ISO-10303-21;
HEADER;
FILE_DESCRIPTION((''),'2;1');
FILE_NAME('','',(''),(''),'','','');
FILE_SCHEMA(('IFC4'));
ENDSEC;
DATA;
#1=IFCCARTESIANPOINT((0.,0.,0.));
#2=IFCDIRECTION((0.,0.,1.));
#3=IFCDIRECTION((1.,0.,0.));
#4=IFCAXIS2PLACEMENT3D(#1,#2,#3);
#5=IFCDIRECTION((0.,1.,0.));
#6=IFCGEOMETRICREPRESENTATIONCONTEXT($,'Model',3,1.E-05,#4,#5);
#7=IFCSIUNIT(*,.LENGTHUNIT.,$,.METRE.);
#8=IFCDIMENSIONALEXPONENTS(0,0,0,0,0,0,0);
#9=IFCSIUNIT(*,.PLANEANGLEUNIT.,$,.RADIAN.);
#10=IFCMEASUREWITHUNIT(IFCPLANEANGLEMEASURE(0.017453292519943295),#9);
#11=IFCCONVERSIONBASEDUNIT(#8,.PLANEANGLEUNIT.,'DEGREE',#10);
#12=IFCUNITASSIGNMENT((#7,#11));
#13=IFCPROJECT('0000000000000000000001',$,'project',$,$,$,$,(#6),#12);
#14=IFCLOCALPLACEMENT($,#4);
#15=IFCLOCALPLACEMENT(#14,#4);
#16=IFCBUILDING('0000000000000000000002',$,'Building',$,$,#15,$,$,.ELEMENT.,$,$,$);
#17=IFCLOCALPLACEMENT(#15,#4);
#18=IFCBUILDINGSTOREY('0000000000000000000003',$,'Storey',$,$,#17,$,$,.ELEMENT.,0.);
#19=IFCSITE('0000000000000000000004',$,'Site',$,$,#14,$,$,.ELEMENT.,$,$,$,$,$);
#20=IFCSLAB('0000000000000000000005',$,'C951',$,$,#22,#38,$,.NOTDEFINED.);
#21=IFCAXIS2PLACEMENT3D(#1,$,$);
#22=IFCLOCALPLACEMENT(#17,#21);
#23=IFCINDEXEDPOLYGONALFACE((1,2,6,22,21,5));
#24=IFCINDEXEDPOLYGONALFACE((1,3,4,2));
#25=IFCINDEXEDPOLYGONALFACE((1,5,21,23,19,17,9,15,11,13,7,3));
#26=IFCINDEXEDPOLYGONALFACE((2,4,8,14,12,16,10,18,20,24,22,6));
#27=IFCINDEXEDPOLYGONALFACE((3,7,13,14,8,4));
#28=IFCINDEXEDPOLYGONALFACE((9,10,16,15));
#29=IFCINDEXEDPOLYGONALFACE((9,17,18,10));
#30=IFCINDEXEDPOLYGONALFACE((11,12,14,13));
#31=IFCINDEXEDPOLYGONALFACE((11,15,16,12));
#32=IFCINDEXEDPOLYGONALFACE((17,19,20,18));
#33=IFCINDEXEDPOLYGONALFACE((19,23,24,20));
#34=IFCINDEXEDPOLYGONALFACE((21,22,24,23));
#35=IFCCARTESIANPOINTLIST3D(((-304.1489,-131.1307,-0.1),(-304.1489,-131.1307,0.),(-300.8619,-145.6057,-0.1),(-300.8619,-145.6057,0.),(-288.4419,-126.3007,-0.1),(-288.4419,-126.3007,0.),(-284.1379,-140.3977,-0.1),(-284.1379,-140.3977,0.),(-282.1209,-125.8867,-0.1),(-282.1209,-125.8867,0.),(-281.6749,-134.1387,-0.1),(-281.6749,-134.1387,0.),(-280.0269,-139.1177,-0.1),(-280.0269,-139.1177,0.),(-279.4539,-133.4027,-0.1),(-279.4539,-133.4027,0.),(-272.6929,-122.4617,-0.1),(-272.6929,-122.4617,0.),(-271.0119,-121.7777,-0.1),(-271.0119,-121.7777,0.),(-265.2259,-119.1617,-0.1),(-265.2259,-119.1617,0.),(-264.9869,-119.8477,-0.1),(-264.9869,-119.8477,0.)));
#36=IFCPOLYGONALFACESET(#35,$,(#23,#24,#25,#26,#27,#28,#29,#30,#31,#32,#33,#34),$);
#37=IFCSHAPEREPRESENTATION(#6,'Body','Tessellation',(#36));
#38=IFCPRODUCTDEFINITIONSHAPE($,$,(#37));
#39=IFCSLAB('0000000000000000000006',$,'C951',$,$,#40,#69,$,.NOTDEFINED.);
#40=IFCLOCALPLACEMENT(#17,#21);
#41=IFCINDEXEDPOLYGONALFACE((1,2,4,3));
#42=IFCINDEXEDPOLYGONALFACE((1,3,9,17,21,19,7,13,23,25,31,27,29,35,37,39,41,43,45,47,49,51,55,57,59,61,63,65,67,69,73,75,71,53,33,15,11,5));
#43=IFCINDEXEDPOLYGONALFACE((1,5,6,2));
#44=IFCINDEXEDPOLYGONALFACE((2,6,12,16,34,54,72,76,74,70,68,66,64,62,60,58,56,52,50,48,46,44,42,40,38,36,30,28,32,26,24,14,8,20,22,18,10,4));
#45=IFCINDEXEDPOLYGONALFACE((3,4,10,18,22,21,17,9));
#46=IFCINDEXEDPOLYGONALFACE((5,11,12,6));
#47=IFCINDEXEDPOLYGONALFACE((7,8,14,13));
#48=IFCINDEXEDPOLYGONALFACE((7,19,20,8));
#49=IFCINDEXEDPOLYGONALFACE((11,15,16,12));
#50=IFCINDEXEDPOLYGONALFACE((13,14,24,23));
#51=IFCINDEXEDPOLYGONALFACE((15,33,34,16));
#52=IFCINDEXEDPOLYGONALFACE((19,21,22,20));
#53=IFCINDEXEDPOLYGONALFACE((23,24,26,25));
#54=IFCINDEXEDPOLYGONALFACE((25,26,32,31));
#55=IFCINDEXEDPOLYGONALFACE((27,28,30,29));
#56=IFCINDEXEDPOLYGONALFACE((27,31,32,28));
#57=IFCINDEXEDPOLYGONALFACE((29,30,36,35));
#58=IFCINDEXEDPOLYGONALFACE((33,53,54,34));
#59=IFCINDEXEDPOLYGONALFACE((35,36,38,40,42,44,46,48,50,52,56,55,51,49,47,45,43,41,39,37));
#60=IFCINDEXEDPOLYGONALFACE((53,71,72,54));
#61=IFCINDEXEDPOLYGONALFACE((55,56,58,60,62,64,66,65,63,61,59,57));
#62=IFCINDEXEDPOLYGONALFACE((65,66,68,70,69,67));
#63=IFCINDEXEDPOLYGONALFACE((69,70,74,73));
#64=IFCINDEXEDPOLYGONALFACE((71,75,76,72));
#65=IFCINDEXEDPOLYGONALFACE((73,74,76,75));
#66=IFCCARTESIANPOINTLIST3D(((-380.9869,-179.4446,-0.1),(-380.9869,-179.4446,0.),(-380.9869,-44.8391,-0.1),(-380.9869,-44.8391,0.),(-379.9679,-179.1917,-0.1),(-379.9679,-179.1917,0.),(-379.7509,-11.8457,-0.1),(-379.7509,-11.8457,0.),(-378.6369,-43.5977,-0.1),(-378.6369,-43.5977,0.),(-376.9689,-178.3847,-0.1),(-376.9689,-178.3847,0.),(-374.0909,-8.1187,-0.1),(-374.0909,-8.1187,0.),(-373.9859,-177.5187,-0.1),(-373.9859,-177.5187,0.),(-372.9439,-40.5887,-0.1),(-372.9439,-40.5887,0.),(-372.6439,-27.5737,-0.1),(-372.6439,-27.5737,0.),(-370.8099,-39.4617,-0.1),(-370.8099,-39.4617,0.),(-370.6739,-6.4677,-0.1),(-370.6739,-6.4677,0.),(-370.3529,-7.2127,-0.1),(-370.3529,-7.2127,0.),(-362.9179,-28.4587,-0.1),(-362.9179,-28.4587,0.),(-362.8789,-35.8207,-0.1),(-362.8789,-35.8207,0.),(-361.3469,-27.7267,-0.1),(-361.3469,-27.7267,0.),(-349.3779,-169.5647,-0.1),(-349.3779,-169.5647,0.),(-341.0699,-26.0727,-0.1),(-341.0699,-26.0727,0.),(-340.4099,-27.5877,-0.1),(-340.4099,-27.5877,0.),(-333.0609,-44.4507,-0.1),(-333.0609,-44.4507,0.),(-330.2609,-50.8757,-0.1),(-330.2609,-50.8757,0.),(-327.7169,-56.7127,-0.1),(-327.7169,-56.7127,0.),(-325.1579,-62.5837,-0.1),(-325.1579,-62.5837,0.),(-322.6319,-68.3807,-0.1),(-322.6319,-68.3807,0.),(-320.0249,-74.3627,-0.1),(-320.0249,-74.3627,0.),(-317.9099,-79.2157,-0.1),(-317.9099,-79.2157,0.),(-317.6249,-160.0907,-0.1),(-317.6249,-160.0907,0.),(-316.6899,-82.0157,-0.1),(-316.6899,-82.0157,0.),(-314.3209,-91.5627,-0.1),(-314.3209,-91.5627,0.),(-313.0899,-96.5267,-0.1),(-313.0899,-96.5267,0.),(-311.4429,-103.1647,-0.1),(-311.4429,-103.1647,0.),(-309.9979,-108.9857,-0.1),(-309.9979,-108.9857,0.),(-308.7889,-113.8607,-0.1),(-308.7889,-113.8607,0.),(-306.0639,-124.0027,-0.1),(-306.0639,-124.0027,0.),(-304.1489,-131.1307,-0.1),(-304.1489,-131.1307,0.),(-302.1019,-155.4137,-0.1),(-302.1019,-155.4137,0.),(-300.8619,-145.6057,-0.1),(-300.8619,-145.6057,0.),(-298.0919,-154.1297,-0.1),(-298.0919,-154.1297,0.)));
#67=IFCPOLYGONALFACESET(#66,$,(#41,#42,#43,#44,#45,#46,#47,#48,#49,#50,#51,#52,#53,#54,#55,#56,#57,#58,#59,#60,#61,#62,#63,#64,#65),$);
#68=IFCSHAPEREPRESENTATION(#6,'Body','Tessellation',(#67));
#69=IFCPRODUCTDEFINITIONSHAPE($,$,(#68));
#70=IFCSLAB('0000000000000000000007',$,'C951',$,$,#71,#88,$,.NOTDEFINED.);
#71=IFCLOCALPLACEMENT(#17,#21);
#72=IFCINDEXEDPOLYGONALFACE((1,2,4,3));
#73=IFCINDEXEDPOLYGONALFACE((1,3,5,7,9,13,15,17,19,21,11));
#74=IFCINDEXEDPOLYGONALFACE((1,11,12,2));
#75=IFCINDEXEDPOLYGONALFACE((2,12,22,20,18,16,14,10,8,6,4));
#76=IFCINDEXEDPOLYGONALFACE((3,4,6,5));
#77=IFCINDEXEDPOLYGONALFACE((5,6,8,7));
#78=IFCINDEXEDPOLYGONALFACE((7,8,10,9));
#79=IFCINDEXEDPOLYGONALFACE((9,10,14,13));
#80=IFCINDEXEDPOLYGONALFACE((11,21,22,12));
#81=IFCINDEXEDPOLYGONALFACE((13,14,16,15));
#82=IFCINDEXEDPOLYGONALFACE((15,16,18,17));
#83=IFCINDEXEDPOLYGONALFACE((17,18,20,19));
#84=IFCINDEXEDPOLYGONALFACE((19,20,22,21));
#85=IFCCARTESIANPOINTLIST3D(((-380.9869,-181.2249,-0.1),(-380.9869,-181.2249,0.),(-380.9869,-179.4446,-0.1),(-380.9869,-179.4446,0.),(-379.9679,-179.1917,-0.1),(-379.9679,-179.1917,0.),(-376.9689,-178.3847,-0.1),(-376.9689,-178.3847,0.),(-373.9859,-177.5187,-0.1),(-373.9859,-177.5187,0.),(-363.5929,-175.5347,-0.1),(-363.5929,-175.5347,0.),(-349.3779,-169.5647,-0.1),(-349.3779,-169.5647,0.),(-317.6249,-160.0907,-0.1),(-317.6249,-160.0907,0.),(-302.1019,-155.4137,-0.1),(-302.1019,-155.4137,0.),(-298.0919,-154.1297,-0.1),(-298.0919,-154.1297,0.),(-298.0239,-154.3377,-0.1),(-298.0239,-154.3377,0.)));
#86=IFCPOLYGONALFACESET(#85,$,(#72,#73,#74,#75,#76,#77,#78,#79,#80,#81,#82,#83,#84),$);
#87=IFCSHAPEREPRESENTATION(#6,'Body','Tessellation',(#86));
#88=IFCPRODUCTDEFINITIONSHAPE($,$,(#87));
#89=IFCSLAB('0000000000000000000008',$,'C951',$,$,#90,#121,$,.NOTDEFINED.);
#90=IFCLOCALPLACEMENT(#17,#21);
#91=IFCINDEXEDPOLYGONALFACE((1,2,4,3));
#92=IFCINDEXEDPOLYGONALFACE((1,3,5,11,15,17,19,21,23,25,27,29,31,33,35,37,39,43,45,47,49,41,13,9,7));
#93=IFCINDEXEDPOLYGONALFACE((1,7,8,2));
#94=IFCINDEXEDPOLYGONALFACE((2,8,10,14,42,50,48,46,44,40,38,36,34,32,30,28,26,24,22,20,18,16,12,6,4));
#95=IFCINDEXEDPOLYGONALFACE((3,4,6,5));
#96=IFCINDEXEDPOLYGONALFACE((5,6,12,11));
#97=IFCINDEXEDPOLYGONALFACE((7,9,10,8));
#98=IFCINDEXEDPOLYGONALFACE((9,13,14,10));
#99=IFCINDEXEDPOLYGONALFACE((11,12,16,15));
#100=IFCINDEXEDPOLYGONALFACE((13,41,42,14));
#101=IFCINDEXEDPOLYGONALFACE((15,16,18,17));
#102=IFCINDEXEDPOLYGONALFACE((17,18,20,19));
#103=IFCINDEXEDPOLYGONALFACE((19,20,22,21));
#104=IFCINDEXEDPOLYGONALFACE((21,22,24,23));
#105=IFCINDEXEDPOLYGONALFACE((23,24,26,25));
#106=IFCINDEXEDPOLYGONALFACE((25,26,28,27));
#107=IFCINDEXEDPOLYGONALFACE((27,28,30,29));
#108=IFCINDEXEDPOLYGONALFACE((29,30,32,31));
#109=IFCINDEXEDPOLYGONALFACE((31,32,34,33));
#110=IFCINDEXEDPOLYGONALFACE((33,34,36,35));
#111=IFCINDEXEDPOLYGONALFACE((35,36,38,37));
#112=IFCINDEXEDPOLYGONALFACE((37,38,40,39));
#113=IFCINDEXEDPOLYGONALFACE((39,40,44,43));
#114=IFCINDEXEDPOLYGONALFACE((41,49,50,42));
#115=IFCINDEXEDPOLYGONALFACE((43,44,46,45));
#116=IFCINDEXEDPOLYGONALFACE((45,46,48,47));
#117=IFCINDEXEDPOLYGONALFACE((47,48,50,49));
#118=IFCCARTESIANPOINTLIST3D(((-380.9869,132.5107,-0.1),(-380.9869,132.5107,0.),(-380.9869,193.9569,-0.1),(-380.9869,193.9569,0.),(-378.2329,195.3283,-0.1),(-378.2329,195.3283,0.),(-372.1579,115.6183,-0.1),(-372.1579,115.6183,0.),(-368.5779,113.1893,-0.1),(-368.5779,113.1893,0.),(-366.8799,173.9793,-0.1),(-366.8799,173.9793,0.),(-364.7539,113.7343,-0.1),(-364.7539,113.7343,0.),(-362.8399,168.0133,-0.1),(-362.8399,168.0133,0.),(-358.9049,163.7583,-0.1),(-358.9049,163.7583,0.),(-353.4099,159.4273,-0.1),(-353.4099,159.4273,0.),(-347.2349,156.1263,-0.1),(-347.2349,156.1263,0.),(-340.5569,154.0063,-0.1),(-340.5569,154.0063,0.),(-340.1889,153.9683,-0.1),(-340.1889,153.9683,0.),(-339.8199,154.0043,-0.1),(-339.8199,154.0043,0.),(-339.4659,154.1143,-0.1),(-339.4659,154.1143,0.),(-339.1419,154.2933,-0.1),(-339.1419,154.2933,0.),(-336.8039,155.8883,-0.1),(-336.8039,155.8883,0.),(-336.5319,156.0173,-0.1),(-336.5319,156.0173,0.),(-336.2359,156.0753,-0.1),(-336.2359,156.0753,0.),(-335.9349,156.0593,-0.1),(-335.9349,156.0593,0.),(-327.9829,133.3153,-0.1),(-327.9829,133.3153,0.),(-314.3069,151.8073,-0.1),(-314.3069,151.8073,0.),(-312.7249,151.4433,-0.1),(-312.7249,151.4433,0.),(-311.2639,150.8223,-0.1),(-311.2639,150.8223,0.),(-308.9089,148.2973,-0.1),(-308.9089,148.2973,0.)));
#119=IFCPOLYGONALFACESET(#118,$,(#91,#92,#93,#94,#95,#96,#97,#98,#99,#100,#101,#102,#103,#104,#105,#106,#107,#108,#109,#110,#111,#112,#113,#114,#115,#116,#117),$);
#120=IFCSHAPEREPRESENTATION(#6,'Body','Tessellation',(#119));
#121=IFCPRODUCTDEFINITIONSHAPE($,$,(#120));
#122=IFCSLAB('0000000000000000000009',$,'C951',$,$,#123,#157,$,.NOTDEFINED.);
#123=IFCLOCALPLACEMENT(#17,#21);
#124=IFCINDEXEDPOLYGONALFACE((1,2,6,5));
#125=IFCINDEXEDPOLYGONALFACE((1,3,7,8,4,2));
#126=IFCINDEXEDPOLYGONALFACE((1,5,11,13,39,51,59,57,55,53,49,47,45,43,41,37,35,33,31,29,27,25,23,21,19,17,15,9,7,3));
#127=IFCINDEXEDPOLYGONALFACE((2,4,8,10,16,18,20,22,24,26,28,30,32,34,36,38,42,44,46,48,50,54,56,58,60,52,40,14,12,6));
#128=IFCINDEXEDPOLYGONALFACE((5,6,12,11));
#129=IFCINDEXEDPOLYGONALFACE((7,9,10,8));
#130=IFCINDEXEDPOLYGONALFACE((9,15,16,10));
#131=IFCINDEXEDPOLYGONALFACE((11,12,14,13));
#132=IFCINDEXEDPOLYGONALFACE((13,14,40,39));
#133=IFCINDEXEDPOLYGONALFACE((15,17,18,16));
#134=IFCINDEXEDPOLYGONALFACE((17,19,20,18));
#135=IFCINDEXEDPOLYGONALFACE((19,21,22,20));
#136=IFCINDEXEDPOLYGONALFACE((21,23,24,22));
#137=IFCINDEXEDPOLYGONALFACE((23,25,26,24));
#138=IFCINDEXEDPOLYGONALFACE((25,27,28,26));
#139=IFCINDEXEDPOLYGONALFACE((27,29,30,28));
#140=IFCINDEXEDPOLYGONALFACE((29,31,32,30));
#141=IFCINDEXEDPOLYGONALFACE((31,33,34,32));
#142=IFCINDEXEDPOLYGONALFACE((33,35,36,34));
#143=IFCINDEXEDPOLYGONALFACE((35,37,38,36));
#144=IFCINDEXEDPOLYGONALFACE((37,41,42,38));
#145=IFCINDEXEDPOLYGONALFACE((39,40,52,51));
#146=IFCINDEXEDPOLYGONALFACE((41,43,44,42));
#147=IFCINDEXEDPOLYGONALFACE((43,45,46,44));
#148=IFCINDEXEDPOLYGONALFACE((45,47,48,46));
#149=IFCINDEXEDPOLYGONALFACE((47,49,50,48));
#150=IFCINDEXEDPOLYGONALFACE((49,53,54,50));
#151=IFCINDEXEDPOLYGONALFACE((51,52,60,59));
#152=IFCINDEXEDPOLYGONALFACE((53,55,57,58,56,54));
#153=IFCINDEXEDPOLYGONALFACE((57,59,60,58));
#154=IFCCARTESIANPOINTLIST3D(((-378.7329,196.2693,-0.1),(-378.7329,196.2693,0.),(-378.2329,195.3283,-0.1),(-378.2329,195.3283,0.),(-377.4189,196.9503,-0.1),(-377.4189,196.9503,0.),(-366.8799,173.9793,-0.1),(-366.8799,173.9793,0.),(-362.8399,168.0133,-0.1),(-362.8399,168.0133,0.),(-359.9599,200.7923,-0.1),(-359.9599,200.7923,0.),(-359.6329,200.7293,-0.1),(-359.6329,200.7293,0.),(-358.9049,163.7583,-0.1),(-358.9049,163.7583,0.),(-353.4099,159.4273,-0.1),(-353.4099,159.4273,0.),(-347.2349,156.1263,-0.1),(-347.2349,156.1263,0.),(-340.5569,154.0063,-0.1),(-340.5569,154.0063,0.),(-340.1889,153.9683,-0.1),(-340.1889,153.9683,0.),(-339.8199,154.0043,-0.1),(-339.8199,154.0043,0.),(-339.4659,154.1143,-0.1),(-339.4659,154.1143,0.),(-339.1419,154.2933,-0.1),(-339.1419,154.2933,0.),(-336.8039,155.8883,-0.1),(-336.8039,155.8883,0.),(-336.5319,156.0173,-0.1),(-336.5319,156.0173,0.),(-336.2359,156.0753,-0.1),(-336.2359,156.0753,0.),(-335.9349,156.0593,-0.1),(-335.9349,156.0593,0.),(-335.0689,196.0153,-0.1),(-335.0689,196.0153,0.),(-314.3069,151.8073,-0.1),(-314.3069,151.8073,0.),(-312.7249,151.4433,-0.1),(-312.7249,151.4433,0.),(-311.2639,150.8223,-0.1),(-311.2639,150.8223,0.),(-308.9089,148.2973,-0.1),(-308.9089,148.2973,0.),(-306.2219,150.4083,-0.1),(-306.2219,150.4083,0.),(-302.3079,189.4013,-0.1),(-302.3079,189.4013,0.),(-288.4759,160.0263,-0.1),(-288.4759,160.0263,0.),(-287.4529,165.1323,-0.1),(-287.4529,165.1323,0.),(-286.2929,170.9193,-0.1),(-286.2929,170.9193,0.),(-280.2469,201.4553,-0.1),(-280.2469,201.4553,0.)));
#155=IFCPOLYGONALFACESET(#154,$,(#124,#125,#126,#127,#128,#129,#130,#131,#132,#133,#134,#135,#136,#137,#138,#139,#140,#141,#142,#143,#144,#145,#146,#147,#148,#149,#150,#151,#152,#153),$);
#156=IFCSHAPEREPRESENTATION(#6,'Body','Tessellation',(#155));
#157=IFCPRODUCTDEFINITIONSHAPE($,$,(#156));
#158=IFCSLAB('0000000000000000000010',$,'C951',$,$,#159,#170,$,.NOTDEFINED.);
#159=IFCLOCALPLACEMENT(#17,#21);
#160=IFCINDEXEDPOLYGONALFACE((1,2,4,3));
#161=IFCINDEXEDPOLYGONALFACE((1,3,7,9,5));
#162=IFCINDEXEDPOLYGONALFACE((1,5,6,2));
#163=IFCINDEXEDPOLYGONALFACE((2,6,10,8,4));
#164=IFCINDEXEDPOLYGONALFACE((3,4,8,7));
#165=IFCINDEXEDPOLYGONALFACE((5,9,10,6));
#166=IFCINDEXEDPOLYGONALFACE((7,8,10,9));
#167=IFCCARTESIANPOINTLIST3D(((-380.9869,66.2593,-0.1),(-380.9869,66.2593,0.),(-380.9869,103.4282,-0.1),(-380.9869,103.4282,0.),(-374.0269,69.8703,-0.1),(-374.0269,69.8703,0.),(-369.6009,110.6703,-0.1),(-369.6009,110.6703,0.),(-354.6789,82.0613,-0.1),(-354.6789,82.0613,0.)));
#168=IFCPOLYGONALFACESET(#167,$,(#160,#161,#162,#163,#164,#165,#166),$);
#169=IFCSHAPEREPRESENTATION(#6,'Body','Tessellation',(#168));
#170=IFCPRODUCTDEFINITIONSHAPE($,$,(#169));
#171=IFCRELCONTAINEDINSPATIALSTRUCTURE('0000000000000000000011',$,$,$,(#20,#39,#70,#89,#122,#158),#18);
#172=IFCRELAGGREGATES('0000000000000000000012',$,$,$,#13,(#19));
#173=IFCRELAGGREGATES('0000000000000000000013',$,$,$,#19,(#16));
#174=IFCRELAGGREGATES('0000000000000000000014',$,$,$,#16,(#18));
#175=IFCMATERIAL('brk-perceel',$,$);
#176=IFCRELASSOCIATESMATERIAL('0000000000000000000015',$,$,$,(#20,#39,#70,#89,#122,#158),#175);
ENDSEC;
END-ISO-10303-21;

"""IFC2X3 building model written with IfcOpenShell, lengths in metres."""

from ifc_helpers import new_model, entity, si_unit, converted_unit, direction, frame, origin_with_axes, place, context, project, spatial, polyline, outline, extrude, material, element, save


model = new_model("IFC2X3")

# Units and contexts
model_context = context("Model", 3, precision=1e-05, world=origin_with_axes(), true_north=direction((0.0, 1.0, 0.0)))
ifc_project = project(units=[si_unit("LENGTHUNIT", "METRE"), converted_unit("PLANEANGLEUNIT", "DEGREE", entity("IfcPlaneAngleMeasure", 0.017453292519943295), si_unit("PLANEANGLEUNIT", "RADIAN"), dimensions=[0, 0, 0, 0, 0, 0, 0])], contexts=[model_context])

# Site, building, storey
site_placement = place(None, origin_with_axes())
site = spatial("IfcSite", under=ifc_project, at=site_placement, Name="Site", CompositionType="ELEMENT")
building_placement = place(site_placement, origin_with_axes())
building = spatial("IfcBuilding", under=site, at=building_placement, Name="Building", CompositionType="ELEMENT")
storey_placement = place(building_placement, origin_with_axes())
storey = spatial("IfcBuildingStorey", under=building, at=storey_placement, Name="Storey", CompositionType="ELEMENT", Elevation=0.0)

# Slabs
ifc_material = material(Name="brk-perceel")
slab_1_placement = place(storey_placement, frame((0.0, 0.0, -0.1), z_axis=(0.0, 0.0, 1.0), x_axis=(1.0, 0.0, 0.0)))
element("IfcSlab", 1, at=slab_1_placement, inside=storey, material=ifc_material, Name="C951", PredefinedType="NOTDEFINED", context=model_context, shape_type="SweptSolid", body=[
    extrude(outline(polyline([(-304.1489, -131.1307), (-288.4419, -126.3007), (-265.2259, -119.1617), (-264.9869, -119.8477), (-271.0119, -121.7777), (-272.6929, -122.4617), (-282.1209, -125.8867), (-279.4539, -133.4027), (-281.6749, -134.1387), (-280.0269, -139.1177), (-284.1379, -140.3977), (-300.8619, -145.6057), (-304.1489, -131.1307)])), origin_with_axes(), (0.0, 0.0, 1.0), 0.1),
])
slab_2_placement = place(storey_placement, frame((0.0, 0.0, -0.1), z_axis=(0.0, 0.0, 1.0), x_axis=(1.0, 0.0, 0.0)))
element("IfcSlab", 2, at=slab_2_placement, inside=storey, material=ifc_material, Name="C951", PredefinedType="NOTDEFINED", context=model_context, shape_type="SweptSolid", body=[
    extrude(outline(polyline([(-378.6369, -43.5977), (-372.9439, -40.5887), (-370.8099, -39.4617), (-372.6439, -27.5737), (-379.7509, -11.8457), (-374.0909, -8.1187), (-370.6739, -6.4677), (-370.3529, -7.2127), (-361.3469, -27.7267), (-362.9179, -28.4587), (-362.8789, -35.8207), (-341.0699, -26.0727), (-340.4099, -27.5877), (-333.0609, -44.4507), (-330.2609, -50.8757), (-327.7169, -56.7127), (-325.1579, -62.5837), (-322.6319, -68.3807), (-320.0249, -74.3627), (-317.9099, -79.2157), (-316.6899, -82.0157), (-314.3209, -91.5627), (-313.0899, -96.5267), (-311.4429, -103.1647), (-309.9979, -108.9857), (-308.7889, -113.8607), (-306.0639, -124.0027), (-304.1489, -131.1307), (-300.8619, -145.6057), (-298.0919, -154.1297), (-302.1019, -155.4137), (-317.6249, -160.0907), (-349.3779, -169.5647), (-373.9859, -177.5187), (-376.9689, -178.3847), (-379.9679, -179.1917), (-380.9869, -179.4446), (-380.9869, -44.8391), (-378.6369, -43.5977)])), origin_with_axes(), (0.0, 0.0, 1.0), 0.1),
])
slab_3_placement = place(storey_placement, frame((0.0, 0.0, -0.1), z_axis=(0.0, 0.0, 1.0), x_axis=(1.0, 0.0, 0.0)))
element("IfcSlab", 3, at=slab_3_placement, inside=storey, material=ifc_material, Name="C951", PredefinedType="NOTDEFINED", context=model_context, shape_type="SweptSolid", body=[
    extrude(outline(polyline([(-379.9679, -179.1917), (-376.9689, -178.3847), (-373.9859, -177.5187), (-349.3779, -169.5647), (-317.6249, -160.0907), (-302.1019, -155.4137), (-298.0919, -154.1297), (-298.0239, -154.3377), (-363.5929, -175.5347), (-380.9869, -181.2249), (-380.9869, -179.4446), (-379.9679, -179.1917)])), origin_with_axes(), (0.0, 0.0, 1.0), 0.1),
])
slab_4_placement = place(storey_placement, frame((0.0, 0.0, -0.1), z_axis=(0.0, 0.0, 1.0), x_axis=(1.0, 0.0, 0.0)))
element("IfcSlab", 4, at=slab_4_placement, inside=storey, material=ifc_material, Name="C951", PredefinedType="NOTDEFINED", context=model_context, shape_type="SweptSolid", body=[
    extrude(outline(polyline([(-378.2329, 195.3283), (-366.8799, 173.9793), (-362.8399, 168.0133), (-358.9049, 163.7583), (-353.4099, 159.4273), (-347.2349, 156.1263), (-340.5569, 154.0063), (-340.1889, 153.9683), (-339.8199, 154.0043), (-339.4659, 154.1143), (-339.1419, 154.2933), (-336.8039, 155.8883), (-336.5319, 156.0173), (-336.2359, 156.0753), (-335.9349, 156.0593), (-314.3069, 151.8073), (-312.7249, 151.4433), (-311.2639, 150.8223), (-308.9089, 148.2973), (-327.9829, 133.3153), (-364.7539, 113.7343), (-368.5779, 113.1893), (-372.1579, 115.6183), (-380.9869, 132.5107), (-380.9869, 193.9569), (-378.2329, 195.3283)])), origin_with_axes(), (0.0, 0.0, 1.0), 0.1),
])
slab_5_placement = place(storey_placement, frame((0.0, 0.0, -0.1), z_axis=(0.0, 0.0, 1.0), x_axis=(1.0, 0.0, 0.0)))
element("IfcSlab", 5, at=slab_5_placement, inside=storey, material=ifc_material, Name="C951", PredefinedType="NOTDEFINED", context=model_context, shape_type="SweptSolid", body=[
    extrude(outline(polyline([(-311.2639, 150.8223), (-312.7249, 151.4433), (-314.3069, 151.8073), (-335.9349, 156.0593), (-336.2359, 156.0753), (-336.5319, 156.0173), (-336.8039, 155.8883), (-339.1419, 154.2933), (-339.4659, 154.1143), (-339.8199, 154.0043), (-340.1889, 153.9683), (-340.5569, 154.0063), (-347.2349, 156.1263), (-353.4099, 159.4273), (-358.9049, 163.7583), (-362.8399, 168.0133), (-366.8799, 173.9793), (-378.2329, 195.3283), (-378.7329, 196.2693), (-377.4189, 196.9503), (-359.9599, 200.7923), (-359.6329, 200.7293), (-335.0689, 196.0153), (-302.3079, 189.4013), (-280.2469, 201.4553), (-286.2929, 170.9193), (-287.4529, 165.1323), (-288.4759, 160.0263), (-306.2219, 150.4083), (-308.9089, 148.2973), (-311.2639, 150.8223)])), origin_with_axes(), (0.0, 0.0, 1.0), 0.1),
])
slab_6_placement = place(storey_placement, frame((0.0, 0.0, -0.1), z_axis=(0.0, 0.0, 1.0), x_axis=(1.0, 0.0, 0.0)))
element("IfcSlab", 6, at=slab_6_placement, inside=storey, material=ifc_material, Name="C951", PredefinedType="NOTDEFINED", context=model_context, shape_type="SweptSolid", body=[
    extrude(outline(polyline([(-369.6009, 110.6703), (-354.6789, 82.0613), (-374.0269, 69.8703), (-380.9869, 66.2593), (-380.9869, 103.4282), (-369.6009, 110.6703)])), origin_with_axes(), (0.0, 0.0, 1.0), 0.1),
])

save(model, "model.ifc")
